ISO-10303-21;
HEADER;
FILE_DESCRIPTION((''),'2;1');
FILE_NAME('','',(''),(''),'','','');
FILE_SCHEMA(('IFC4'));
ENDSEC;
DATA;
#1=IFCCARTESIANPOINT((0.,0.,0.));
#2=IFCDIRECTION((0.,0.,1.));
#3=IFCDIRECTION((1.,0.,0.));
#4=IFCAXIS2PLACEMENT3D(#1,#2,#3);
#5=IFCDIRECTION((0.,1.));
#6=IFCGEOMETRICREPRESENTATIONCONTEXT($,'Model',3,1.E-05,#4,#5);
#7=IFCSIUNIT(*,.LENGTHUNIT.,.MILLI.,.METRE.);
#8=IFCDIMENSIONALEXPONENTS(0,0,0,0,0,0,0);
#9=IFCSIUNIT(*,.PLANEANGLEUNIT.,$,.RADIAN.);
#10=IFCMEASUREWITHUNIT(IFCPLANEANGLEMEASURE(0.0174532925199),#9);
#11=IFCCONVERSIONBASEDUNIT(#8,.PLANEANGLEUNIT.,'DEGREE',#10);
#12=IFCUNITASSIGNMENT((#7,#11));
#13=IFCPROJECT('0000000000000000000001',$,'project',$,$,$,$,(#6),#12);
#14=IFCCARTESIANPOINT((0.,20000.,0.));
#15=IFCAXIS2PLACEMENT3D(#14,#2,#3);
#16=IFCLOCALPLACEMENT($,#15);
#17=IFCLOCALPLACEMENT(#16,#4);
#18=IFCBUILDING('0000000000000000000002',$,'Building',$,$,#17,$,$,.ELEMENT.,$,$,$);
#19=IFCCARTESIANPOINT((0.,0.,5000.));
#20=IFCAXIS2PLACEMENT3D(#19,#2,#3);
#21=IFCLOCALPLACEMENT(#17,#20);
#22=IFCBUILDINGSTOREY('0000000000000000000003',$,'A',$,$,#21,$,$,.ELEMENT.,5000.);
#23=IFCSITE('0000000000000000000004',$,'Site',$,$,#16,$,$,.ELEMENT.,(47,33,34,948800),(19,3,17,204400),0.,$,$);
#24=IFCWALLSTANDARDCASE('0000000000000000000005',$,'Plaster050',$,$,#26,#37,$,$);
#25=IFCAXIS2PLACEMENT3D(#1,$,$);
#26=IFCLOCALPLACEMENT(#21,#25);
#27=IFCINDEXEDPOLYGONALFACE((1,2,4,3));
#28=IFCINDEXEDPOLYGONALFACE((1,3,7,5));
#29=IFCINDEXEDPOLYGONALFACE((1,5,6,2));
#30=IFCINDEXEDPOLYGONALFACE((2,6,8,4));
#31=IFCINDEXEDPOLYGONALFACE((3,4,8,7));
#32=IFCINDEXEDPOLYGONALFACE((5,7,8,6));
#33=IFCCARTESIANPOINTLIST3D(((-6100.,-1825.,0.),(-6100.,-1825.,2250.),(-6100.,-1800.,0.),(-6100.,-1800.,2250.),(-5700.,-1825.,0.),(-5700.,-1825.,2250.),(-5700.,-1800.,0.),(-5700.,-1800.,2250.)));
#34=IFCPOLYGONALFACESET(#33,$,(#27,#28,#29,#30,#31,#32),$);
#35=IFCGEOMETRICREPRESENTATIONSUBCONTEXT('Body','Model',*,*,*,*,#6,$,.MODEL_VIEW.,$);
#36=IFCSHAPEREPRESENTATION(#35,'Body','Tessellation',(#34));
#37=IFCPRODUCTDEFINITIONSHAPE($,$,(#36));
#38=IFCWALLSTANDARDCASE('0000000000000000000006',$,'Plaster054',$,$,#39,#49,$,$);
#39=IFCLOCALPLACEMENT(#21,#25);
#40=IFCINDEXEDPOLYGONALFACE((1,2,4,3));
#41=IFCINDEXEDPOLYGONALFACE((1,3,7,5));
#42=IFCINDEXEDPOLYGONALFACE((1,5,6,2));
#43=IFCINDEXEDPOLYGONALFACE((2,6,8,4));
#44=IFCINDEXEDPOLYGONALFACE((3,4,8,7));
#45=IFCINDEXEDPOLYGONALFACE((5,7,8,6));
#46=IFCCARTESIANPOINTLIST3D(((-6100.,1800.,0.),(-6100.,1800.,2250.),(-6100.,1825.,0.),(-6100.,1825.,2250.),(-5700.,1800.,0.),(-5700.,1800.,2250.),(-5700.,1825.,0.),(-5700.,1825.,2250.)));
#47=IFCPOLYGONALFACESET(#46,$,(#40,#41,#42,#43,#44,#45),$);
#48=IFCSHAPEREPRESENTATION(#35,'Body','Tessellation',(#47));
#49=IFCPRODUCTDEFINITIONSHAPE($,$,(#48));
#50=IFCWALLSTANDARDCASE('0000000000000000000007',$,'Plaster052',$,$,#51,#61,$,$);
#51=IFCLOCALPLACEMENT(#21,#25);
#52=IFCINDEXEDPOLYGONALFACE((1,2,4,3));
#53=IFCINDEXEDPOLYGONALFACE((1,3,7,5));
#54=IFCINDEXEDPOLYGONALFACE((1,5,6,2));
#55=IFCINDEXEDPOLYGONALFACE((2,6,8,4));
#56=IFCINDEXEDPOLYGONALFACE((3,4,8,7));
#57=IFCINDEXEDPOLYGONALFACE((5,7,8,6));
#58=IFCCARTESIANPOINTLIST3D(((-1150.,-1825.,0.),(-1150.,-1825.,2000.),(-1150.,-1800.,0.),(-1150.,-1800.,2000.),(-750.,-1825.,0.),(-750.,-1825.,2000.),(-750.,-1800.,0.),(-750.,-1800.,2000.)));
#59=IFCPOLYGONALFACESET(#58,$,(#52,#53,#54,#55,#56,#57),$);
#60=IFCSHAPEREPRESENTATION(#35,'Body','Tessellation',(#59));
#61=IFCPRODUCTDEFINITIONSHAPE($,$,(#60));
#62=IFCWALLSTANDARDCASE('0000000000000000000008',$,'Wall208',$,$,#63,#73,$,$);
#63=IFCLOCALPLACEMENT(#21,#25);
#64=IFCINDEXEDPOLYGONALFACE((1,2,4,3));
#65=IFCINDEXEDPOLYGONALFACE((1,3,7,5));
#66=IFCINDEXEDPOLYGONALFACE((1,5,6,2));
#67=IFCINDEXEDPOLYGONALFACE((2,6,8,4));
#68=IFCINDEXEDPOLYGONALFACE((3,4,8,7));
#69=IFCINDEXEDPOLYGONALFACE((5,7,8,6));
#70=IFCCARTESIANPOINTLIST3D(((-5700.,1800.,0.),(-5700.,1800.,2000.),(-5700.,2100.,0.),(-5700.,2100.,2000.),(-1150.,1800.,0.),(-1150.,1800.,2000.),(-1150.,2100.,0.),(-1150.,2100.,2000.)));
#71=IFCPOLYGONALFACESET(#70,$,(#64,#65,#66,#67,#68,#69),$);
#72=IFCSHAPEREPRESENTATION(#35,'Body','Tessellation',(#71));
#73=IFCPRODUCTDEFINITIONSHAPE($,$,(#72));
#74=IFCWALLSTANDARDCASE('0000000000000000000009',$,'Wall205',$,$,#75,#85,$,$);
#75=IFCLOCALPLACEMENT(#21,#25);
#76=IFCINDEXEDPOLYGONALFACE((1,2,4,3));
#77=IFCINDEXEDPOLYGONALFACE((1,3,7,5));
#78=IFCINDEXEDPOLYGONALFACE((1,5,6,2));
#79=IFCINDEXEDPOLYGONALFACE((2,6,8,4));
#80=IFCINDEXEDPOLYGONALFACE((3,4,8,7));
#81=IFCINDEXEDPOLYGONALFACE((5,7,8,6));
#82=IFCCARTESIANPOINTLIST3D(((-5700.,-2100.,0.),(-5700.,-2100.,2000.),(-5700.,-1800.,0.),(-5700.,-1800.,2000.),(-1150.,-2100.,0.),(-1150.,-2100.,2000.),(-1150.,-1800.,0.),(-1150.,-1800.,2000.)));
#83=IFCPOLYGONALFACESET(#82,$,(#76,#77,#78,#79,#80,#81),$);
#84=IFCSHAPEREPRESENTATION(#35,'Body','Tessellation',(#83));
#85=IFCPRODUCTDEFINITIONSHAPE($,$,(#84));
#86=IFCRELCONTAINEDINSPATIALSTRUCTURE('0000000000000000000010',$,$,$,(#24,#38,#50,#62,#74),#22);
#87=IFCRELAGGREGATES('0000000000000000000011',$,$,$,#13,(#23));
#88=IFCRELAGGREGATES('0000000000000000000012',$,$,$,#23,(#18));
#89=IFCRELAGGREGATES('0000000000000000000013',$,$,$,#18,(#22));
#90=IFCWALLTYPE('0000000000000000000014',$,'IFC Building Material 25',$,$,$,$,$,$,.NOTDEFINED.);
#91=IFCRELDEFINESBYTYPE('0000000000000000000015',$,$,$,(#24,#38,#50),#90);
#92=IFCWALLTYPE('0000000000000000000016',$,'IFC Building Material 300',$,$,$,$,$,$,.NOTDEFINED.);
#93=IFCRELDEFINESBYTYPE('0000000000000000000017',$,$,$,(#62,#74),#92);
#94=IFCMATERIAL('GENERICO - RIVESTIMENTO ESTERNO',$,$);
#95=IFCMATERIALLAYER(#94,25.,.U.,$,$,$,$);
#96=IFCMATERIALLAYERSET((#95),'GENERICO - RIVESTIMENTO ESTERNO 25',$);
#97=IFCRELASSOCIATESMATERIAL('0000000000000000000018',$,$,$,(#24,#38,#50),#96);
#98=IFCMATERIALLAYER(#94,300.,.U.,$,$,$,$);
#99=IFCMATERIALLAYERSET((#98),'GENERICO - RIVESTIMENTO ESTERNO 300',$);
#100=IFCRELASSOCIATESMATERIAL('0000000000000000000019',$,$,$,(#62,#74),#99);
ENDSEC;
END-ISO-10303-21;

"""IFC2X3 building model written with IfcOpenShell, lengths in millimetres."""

from ifc_helpers import new_model, entity, si_unit, converted_unit, direction, frame, origin_with_axes, place, context, subcontext, project, spatial, polyline, outline, extrude, material, layer, layer_set, layer_usage, type_object, element, save


model = new_model("IFC2X3")

# Units and contexts
model_context = context("Model", 3, precision=1e-05, world=origin_with_axes(), true_north=direction((0.0, 1.0)))
body_context = subcontext(model_context, "Body", "Model", "MODEL_VIEW")
ifc_project = project(units=[si_unit("LENGTHUNIT", "METRE", prefix="MILLI"), converted_unit("PLANEANGLEUNIT", "DEGREE", entity("IfcPlaneAngleMeasure", 0.0174532925199), si_unit("PLANEANGLEUNIT", "RADIAN"), dimensions=[0, 0, 0, 0, 0, 0, 0])], contexts=[model_context])

# Site, building, storey
site_placement = place(None, frame((0.0, 20000.0, 0.0), z_axis=(0.0, 0.0, 1.0), x_axis=(1.0, 0.0, 0.0)))
site = spatial("IfcSite", under=ifc_project, at=site_placement, Name="Site", CompositionType="ELEMENT", RefLatitude=(47, 33, 34, 948800), RefLongitude=(19, 3, 17, 204400), RefElevation=0.0)
building_placement = place(site_placement, origin_with_axes())
building = spatial("IfcBuilding", under=site, at=building_placement, Name="Building", CompositionType="ELEMENT")
storey_placement = place(building_placement, frame((0.0, 0.0, 5000.0), z_axis=(0.0, 0.0, 1.0), x_axis=(1.0, 0.0, 0.0)))
storey = spatial("IfcBuildingStorey", under=building, at=storey_placement, Name="A", CompositionType="ELEMENT", Elevation=5000.0)

# Shared definitions
ifc_material_1 = material(Name="GENERICO - RIVESTIMENTO ESTERNO")

# Walls
ifc_layer_1 = layer(ifc_material_1, 25.0, ventilated="UNKNOWN")
ifc_layer_set_1 = layer_set([ifc_layer_1], Name="GENERICO - RIVESTIMENTO ESTERNO 25")
wall_type_1 = type_object("IfcWallType", Name="IFC Building Material 25", PredefinedType="NOTDEFINED")
ifc_layer_usage_1 = layer_usage(ifc_layer_set_1, "AXIS2", "POSITIVE", -25.0)
wall_1_placement = place(storey_placement, frame((-6100.0, -1800.0, 0.0), z_axis=(0.0, 0.0, 1.0), x_axis=(1.0, 0.0, 0.0)))
element("IfcWallStandardCase", 1, at=wall_1_placement, inside=storey, type_object=wall_type_1, material=ifc_layer_usage_1, Name="Plaster050", context=body_context, shape_type="SweptSolid", body=[
    extrude(outline(polyline([(0.0, -25.0), (400.0, -25.0), (400.0, 0.0), (0.0, 0.0), (0.0, -25.0)])), origin_with_axes(), (0.0, 0.0, 1.0), 2250.0),
])
ifc_layer_usage_2 = layer_usage(ifc_layer_set_1, "AXIS2", "POSITIVE", 0.0)
wall_2_placement = place(storey_placement, frame((-6100.0, 1800.0, 0.0), z_axis=(0.0, 0.0, 1.0), x_axis=(1.0, 0.0, 0.0)))
element("IfcWallStandardCase", 2, at=wall_2_placement, inside=storey, type_object=wall_type_1, material=ifc_layer_usage_2, Name="Plaster054", context=body_context, shape_type="SweptSolid", body=[
    extrude(outline(polyline([(0.0, 0.0), (400.0, 0.0), (400.0, 25.0), (0.0, 25.0), (0.0, 0.0)])), origin_with_axes(), (0.0, 0.0, 1.0), 2250.0),
])
ifc_layer_usage_3 = layer_usage(ifc_layer_set_1, "AXIS2", "POSITIVE", -25.0)
wall_3_placement = place(storey_placement, frame((-1150.0, -1800.0, 0.0), z_axis=(0.0, 0.0, 1.0), x_axis=(1.0, 0.0, 0.0)))
element("IfcWallStandardCase", 3, at=wall_3_placement, inside=storey, type_object=wall_type_1, material=ifc_layer_usage_3, Name="Plaster052", context=body_context, shape_type="SweptSolid", body=[
    extrude(outline(polyline([(0.0, -25.0), (400.0, -25.0), (400.0, 0.0), (0.0, 0.0), (0.0, -25.0)])), origin_with_axes(), (0.0, 0.0, 1.0), 2000.0),
])
ifc_layer_2 = layer(ifc_material_1, 300.0, ventilated="UNKNOWN")
ifc_layer_set_2 = layer_set([ifc_layer_2], Name="GENERICO - RIVESTIMENTO ESTERNO 300")
ifc_layer_usage_4 = layer_usage(ifc_layer_set_2, "AXIS2", "POSITIVE", -300.0)
wall_type_2 = type_object("IfcWallType", Name="IFC Building Material 300", PredefinedType="NOTDEFINED")
wall_4_placement = place(storey_placement, frame((-1150.0, 1800.0, 0.0), z_axis=(0.0, 0.0, 1.0), x_axis=(-1.0, 0.0, 0.0)))
element("IfcWallStandardCase", 4, at=wall_4_placement, inside=storey, type_object=wall_type_2, material=ifc_layer_usage_4, Name="Wall208", context=body_context, shape_type="SweptSolid", body=[
    extrude(outline(polyline([(0.0, -300.0), (4550.0, -300.0), (4550.0, 0.0), (0.0, 0.0), (0.0, -300.0)])), origin_with_axes(), (0.0, 0.0, 1.0), 2000.0),
])
ifc_layer_usage_5 = layer_usage(ifc_layer_set_2, "AXIS2", "POSITIVE", 0.0)
wall_5_placement = place(storey_placement, frame((-1150.0, -1800.0, 0.0), z_axis=(0.0, 0.0, 1.0), x_axis=(-1.0, 0.0, 0.0)))
element("IfcWallStandardCase", 5, at=wall_5_placement, inside=storey, type_object=wall_type_2, material=ifc_layer_usage_5, Name="Wall205", context=body_context, shape_type="SweptSolid", body=[
    extrude(outline(polyline([(0.0, 0.0), (4550.0, 0.0), (4550.0, 300.0), (0.0, 300.0), (0.0, 0.0)])), origin_with_axes(), (0.0, 0.0, 1.0), 2000.0),
])

save(model, "model.ifc")
